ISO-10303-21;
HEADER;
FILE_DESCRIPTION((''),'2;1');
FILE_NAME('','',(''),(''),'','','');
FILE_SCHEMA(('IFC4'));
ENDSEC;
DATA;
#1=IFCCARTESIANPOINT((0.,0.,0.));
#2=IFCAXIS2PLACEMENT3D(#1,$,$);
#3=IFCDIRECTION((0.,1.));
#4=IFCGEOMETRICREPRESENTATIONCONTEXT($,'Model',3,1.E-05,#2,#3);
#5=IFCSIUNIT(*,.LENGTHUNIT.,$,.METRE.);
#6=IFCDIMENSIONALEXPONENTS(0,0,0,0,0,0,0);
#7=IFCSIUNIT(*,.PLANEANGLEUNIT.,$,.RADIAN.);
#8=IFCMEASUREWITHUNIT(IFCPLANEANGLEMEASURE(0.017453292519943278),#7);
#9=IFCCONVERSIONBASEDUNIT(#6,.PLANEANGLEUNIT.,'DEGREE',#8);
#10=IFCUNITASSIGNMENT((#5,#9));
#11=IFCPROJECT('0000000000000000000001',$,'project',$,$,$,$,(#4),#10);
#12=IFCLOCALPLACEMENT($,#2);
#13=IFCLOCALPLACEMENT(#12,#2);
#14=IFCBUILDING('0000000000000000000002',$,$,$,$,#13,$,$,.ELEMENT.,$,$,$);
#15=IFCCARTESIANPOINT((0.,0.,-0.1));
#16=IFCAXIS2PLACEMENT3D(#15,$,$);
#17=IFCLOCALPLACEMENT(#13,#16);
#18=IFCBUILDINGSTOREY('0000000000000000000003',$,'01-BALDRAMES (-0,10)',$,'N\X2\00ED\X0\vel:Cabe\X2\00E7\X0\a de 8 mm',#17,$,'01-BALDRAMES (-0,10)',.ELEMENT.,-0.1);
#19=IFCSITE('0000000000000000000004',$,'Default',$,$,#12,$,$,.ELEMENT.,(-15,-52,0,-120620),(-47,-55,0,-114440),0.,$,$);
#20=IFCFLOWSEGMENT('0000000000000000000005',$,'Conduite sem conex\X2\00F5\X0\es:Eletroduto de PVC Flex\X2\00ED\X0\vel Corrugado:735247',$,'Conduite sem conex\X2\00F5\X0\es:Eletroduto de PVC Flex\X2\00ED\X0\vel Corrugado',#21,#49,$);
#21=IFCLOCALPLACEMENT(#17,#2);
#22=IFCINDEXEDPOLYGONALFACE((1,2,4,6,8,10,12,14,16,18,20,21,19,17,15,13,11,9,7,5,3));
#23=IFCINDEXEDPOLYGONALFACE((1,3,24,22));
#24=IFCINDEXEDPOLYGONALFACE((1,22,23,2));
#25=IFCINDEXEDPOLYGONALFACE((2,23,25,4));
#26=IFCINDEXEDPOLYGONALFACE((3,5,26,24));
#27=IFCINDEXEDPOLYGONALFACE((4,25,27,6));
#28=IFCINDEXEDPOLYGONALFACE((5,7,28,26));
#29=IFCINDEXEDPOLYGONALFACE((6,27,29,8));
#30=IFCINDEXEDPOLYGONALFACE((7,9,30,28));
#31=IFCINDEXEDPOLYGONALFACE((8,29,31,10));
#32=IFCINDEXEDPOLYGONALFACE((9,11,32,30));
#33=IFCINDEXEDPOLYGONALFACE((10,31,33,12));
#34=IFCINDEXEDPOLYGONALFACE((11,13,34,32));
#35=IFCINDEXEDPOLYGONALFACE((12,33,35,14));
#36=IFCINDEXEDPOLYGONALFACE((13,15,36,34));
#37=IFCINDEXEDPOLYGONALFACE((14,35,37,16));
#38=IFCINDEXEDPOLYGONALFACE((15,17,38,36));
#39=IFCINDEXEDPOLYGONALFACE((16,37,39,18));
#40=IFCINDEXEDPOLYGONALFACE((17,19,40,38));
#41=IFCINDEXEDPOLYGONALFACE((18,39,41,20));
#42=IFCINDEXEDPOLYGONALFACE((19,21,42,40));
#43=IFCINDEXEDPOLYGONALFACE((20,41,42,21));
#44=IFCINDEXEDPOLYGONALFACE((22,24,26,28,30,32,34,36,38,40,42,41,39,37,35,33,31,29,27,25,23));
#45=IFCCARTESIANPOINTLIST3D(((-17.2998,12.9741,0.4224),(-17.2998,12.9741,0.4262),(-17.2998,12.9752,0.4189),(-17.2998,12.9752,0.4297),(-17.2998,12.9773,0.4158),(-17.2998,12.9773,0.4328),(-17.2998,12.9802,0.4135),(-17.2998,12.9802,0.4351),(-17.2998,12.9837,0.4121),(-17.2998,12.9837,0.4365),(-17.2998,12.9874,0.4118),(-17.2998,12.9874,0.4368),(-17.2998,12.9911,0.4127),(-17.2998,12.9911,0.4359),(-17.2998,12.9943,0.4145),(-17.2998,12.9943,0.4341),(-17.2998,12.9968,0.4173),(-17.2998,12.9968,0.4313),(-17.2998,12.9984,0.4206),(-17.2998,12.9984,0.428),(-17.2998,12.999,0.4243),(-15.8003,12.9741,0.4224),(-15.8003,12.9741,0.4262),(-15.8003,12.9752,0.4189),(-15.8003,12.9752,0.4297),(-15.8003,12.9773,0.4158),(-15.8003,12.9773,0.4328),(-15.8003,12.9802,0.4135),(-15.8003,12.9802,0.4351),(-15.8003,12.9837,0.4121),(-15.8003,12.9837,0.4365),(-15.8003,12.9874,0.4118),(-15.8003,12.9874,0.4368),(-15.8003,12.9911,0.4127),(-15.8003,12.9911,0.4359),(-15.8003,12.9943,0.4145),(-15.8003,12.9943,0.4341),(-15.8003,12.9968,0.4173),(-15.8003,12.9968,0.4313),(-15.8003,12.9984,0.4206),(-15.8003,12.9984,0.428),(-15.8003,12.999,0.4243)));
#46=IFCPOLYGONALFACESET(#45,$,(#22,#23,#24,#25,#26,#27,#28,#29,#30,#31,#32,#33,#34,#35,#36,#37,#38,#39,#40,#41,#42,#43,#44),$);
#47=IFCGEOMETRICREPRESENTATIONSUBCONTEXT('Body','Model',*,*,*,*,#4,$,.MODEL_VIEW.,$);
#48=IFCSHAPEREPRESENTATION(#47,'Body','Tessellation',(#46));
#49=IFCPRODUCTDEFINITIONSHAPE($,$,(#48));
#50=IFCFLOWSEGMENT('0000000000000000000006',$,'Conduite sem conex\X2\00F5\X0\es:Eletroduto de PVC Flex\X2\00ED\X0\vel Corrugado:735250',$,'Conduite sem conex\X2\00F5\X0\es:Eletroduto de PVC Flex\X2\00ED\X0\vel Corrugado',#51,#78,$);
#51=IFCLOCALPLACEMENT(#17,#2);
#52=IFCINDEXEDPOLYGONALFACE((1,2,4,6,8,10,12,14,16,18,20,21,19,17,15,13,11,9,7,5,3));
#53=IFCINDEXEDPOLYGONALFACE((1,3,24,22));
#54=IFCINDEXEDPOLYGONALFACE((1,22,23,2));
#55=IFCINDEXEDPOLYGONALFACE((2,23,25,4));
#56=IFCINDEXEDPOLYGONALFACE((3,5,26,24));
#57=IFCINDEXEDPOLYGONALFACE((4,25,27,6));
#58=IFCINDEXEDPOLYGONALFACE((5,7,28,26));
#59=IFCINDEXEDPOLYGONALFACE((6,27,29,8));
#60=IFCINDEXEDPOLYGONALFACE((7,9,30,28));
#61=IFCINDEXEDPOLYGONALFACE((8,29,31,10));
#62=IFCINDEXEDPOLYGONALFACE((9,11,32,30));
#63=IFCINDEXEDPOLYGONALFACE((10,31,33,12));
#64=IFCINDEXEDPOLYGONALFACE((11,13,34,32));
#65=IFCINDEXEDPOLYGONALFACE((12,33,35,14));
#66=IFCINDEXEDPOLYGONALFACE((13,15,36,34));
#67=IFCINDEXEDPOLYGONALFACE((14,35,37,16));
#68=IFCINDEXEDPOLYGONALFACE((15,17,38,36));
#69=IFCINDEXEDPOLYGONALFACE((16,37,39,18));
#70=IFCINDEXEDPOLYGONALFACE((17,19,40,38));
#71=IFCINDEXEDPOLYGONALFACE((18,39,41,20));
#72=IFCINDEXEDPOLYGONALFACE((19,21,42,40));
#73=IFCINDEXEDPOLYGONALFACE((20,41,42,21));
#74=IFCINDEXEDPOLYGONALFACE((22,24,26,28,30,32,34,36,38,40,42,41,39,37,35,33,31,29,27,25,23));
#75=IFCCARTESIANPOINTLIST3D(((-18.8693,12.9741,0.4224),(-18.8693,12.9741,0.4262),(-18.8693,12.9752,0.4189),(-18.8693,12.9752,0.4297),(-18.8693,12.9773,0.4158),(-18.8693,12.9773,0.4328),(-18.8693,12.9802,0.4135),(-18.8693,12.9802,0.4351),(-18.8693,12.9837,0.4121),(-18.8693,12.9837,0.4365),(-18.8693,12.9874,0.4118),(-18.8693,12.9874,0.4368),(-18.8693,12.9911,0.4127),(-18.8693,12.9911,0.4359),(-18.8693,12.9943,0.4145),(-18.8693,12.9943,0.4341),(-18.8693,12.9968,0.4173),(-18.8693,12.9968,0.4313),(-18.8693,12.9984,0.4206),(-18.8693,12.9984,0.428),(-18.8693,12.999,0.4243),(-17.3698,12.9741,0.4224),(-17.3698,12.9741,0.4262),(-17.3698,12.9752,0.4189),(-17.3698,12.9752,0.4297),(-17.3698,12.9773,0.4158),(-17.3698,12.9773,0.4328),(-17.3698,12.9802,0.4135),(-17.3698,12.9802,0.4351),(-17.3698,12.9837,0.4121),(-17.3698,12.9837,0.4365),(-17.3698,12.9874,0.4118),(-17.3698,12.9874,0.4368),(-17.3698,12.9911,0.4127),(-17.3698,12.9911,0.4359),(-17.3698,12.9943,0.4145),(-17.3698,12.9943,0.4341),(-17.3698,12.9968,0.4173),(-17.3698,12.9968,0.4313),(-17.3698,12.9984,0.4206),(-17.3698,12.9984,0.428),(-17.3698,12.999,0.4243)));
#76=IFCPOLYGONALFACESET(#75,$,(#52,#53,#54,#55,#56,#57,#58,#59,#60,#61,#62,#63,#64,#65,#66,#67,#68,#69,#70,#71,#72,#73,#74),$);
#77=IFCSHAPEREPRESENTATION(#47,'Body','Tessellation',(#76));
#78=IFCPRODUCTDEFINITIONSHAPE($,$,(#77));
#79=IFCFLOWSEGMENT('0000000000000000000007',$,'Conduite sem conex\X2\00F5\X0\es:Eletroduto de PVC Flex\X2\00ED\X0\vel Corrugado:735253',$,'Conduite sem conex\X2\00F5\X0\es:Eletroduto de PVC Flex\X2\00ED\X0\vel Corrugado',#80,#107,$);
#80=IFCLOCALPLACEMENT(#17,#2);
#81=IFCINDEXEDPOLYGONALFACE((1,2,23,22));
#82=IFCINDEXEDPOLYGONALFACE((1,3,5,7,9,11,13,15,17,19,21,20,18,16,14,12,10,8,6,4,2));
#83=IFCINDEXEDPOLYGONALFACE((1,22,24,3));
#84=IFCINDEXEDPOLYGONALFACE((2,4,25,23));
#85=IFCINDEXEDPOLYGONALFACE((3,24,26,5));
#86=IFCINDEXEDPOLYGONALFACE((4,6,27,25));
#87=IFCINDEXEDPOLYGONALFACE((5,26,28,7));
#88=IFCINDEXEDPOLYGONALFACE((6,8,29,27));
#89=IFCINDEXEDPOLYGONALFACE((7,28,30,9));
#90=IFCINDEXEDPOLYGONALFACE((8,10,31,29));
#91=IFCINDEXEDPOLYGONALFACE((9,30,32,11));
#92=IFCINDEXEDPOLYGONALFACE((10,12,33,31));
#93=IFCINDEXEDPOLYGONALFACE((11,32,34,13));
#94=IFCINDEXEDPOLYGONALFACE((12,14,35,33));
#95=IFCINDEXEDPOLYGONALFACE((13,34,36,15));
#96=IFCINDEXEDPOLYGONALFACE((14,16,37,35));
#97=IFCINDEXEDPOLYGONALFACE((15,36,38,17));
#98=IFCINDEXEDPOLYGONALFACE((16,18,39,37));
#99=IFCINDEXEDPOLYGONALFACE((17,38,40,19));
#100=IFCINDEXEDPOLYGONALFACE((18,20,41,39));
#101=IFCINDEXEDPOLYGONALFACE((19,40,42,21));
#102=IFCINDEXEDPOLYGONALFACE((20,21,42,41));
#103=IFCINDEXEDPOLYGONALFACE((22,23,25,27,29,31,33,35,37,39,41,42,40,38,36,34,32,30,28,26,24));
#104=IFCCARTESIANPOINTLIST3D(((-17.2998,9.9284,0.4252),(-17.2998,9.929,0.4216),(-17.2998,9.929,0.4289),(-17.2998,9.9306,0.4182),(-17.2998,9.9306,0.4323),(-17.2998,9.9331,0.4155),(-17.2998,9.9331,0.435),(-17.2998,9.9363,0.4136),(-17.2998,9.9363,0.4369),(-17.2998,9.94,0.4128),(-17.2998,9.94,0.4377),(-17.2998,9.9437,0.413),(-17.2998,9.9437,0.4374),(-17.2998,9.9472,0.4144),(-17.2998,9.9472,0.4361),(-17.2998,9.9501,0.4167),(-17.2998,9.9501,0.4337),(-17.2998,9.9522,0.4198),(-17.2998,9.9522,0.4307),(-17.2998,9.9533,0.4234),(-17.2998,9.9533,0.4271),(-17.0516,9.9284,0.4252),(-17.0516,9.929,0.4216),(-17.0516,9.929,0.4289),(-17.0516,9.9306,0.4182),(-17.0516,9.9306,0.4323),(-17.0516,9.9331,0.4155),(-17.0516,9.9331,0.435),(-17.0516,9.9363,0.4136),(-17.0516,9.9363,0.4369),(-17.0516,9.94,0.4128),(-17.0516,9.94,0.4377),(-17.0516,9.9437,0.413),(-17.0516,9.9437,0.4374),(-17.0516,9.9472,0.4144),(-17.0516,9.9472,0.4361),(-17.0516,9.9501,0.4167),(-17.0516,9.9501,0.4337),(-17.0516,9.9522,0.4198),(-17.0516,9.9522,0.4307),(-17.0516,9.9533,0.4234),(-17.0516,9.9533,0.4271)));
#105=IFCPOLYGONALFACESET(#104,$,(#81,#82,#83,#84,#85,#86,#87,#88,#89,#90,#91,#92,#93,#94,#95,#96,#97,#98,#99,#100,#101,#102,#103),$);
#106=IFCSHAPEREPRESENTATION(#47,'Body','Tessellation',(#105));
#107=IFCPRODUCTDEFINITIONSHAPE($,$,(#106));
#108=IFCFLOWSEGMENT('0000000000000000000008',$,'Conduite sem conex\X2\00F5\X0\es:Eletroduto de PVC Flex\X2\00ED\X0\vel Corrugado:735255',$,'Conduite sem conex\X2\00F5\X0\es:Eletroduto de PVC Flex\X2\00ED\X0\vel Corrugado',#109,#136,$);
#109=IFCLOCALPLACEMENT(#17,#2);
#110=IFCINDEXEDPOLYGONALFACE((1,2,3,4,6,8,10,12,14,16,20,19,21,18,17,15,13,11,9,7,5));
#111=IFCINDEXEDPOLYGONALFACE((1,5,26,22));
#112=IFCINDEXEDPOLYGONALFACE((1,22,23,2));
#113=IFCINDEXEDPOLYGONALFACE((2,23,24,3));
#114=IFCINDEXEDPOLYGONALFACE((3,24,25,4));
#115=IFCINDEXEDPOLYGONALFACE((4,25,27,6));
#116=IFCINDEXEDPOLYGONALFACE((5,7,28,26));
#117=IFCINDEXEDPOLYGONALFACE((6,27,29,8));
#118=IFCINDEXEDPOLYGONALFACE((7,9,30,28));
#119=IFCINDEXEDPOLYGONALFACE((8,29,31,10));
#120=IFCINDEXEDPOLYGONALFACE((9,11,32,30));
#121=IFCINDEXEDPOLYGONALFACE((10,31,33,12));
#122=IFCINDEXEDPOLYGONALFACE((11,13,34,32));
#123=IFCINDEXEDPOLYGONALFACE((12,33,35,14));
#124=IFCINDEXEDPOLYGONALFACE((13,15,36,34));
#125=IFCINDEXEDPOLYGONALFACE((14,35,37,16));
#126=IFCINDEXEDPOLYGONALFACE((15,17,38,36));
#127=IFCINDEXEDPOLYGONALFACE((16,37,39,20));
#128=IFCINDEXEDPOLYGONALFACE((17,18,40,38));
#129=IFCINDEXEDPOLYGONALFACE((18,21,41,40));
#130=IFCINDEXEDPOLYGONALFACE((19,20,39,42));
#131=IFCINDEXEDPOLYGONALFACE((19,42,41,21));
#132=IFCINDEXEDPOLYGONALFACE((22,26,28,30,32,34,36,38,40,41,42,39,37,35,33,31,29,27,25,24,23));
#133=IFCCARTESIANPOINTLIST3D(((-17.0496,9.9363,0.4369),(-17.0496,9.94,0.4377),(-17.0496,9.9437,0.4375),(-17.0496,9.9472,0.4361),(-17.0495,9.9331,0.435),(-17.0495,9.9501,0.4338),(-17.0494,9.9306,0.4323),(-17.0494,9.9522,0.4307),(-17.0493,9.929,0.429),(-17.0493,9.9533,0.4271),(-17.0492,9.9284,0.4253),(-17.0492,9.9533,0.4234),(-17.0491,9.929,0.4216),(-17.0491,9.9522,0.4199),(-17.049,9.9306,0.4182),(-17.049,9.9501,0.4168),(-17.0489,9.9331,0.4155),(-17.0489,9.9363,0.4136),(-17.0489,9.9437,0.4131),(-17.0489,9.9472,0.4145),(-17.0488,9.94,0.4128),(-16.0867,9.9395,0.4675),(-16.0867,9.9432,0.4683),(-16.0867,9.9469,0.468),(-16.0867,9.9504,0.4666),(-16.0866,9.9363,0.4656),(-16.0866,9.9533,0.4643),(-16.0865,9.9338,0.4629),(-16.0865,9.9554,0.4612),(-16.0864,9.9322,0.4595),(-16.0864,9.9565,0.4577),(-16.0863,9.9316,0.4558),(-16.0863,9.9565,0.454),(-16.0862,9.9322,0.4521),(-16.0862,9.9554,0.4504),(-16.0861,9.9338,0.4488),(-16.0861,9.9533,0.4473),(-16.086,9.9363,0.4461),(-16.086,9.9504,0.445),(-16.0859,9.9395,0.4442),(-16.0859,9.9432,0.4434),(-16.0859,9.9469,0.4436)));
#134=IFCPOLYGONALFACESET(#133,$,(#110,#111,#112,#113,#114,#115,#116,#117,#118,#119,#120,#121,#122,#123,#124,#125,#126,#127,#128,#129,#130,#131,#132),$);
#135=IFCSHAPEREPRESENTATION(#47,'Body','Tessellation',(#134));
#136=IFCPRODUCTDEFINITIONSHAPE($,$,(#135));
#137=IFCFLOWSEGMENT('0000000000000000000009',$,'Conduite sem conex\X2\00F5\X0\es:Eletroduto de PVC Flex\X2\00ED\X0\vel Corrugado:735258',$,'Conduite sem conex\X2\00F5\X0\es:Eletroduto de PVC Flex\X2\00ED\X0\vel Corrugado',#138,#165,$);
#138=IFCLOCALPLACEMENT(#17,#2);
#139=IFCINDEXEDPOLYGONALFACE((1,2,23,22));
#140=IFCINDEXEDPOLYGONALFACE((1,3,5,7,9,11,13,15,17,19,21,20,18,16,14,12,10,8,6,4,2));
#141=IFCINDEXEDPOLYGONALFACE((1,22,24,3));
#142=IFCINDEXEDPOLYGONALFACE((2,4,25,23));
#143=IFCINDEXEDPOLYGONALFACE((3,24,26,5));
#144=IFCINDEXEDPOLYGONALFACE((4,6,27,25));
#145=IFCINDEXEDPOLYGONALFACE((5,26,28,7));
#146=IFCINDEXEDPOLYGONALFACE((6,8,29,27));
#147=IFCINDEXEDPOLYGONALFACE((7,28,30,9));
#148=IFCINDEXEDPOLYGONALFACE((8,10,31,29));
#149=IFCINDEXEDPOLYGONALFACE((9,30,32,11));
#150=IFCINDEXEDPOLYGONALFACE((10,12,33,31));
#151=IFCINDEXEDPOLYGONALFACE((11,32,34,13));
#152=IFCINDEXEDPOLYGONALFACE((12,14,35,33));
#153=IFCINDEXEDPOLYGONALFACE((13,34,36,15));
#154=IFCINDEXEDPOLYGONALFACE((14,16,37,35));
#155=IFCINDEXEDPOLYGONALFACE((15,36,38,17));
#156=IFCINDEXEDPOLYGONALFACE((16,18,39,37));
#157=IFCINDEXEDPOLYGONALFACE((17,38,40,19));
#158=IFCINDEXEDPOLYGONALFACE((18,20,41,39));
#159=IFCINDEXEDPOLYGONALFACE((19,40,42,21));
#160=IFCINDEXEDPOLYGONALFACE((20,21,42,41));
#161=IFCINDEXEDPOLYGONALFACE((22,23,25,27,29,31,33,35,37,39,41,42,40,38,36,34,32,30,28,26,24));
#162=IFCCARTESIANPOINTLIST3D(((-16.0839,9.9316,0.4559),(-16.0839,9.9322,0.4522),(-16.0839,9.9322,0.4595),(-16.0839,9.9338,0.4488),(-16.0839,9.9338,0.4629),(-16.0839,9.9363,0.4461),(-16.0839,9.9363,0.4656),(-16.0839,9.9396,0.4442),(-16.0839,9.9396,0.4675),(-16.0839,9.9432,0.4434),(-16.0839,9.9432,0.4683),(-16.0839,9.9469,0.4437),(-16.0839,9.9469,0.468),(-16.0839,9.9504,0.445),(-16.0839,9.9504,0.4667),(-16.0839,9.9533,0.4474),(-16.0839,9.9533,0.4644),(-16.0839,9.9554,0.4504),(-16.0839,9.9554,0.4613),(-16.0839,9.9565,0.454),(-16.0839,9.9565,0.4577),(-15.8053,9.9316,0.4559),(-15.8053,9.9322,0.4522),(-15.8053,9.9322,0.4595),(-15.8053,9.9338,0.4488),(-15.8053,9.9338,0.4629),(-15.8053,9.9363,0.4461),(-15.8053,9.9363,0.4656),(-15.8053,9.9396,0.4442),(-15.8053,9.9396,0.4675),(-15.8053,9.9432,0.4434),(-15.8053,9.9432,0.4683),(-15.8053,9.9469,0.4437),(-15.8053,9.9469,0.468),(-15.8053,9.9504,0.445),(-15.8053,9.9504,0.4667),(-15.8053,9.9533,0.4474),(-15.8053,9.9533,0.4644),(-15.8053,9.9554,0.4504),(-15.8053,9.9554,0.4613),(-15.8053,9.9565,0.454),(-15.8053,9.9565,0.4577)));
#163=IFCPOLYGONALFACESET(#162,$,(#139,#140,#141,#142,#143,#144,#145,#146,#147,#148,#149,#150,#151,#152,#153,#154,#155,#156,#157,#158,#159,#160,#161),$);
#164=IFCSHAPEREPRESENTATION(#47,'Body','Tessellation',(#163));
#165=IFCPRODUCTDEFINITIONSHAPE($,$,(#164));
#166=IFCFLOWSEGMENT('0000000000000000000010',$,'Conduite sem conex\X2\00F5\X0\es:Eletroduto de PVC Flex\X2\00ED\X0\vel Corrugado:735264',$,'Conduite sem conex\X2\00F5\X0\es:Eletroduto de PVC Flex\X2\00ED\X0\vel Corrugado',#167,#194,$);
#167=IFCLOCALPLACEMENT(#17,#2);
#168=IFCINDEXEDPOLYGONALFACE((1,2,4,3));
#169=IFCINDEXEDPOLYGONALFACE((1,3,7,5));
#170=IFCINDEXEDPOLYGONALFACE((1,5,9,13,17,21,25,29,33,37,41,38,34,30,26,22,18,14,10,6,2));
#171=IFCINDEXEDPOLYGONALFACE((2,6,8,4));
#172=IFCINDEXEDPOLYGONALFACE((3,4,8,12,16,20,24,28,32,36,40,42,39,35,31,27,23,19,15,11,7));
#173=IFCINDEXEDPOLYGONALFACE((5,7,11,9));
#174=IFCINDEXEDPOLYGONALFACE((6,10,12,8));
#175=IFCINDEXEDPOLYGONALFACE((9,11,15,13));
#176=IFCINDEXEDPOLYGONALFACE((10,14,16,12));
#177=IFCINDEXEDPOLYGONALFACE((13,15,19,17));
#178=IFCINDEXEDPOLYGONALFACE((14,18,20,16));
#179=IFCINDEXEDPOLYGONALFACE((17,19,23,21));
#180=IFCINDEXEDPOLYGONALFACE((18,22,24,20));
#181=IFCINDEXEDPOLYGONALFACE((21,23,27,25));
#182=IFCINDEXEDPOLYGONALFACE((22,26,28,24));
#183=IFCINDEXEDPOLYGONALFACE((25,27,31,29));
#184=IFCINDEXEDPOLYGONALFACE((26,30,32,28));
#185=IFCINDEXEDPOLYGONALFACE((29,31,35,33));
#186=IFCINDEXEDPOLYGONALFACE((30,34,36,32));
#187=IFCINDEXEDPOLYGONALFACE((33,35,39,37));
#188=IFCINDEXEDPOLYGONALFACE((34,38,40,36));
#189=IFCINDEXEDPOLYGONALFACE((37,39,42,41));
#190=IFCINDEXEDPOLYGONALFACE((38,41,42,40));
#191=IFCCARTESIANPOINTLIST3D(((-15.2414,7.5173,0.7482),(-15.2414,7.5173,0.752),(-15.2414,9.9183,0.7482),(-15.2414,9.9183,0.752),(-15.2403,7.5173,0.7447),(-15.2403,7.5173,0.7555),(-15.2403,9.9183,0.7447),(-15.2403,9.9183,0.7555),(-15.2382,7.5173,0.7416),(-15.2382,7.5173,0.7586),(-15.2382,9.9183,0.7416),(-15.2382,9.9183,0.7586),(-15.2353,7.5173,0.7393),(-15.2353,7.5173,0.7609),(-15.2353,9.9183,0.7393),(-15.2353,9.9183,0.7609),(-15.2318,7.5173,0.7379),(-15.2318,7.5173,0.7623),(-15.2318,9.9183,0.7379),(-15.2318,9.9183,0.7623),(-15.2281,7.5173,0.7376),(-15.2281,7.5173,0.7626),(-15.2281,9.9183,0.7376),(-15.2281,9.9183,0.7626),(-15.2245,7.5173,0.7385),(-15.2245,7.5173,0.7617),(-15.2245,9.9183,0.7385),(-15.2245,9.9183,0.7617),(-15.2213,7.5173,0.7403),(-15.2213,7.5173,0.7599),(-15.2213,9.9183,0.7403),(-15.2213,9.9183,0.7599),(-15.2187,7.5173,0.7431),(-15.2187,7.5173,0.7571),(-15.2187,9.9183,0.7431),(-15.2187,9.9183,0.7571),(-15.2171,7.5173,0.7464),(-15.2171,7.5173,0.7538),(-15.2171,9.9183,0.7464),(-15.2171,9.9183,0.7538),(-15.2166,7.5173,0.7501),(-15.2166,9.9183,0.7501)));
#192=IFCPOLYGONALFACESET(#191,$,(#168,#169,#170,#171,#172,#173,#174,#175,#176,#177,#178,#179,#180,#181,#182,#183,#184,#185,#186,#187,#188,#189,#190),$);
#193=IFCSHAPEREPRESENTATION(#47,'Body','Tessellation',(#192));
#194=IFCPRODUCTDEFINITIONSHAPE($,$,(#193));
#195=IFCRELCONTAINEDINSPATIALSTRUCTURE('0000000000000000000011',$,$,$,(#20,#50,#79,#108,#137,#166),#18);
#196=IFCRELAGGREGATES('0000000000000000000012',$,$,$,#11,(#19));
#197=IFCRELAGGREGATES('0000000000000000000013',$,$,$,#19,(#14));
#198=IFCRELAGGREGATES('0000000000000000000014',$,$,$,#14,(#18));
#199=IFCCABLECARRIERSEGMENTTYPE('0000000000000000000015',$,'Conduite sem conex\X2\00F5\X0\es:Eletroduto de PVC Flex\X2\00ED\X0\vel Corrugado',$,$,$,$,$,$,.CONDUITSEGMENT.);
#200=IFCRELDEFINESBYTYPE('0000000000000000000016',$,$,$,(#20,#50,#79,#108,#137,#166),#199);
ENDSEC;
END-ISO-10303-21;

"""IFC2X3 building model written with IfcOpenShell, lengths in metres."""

from ifc_helpers import new_model, entity, si_unit, converted_unit, direction, frame, frame_2d, origin, origin_2d_with_axis, place, context, subcontext, project, spatial, circle, extrude, type_object, element, save


model = new_model("IFC2X3")

# Units and contexts
model_context = context("Model", 3, precision=1e-05, world=origin(), true_north=direction((0.0, 1.0)))
body_context = subcontext(model_context, "Body", "Model", "MODEL_VIEW")
ifc_project = project(units=[si_unit("LENGTHUNIT", "METRE"), converted_unit("PLANEANGLEUNIT", "DEGREE", entity("IfcPlaneAngleMeasure", 0.017453292519943278), si_unit("PLANEANGLEUNIT", "RADIAN"), dimensions=[0, 0, 0, 0, 0, 0, 0])], contexts=[model_context])

# Site, building, storey
site_placement = place(None, origin())
site = spatial("IfcSite", under=ifc_project, at=site_placement, Name="Default", CompositionType="ELEMENT", RefLatitude=(-15, -52, 0, -120620), RefLongitude=(-47, -55, 0, -114440), RefElevation=0.0)
building_placement = place(site_placement, origin())
building = spatial("IfcBuilding", under=site, at=building_placement, CompositionType="ELEMENT")
storey_placement = place(building_placement, frame((0.0, 0.0, -0.1)))
storey = spatial("IfcBuildingStorey", under=building, at=storey_placement, Name="01-BALDRAMES (-0,10)", ObjectType="Nível:Cabeça de 8 mm", LongName="01-BALDRAMES (-0,10)", CompositionType="ELEMENT", Elevation=-0.1)

# Flow segments
cable_carrier_segment_type = type_object("IfcCableCarrierSegmentType", Name="Conduite sem conexões:Eletroduto de PVC Flexível Corrugado", PredefinedType="CONDUITSEGMENT")
flow_segment_1_placement = place(storey_placement, origin())
element("IfcFlowSegment", 1, at=flow_segment_1_placement, inside=storey, type_object=cable_carrier_segment_type, Name="Conduite sem conexões:Eletroduto de PVC Flexível Corrugado:735247", ObjectType="Conduite sem conexões:Eletroduto de PVC Flexível Corrugado", context=body_context, shape_type="SweptSolid", body=[
    extrude(circle(Radius=0.0125, at=frame_2d((0.0, 0.0), x_axis=(1.0, 0.0))), frame((-17.2998, 12.9865, 0.4243), z_axis=(1.0, 0.0, 0.0), x_axis=(0.0, 1.0, 0.0)), (0.0, 0.0, 1.0), 1.4995),
])
flow_segment_2_placement = place(storey_placement, origin())
element("IfcFlowSegment", 2, at=flow_segment_2_placement, inside=storey, type_object=cable_carrier_segment_type, Name="Conduite sem conexões:Eletroduto de PVC Flexível Corrugado:735250", ObjectType="Conduite sem conexões:Eletroduto de PVC Flexível Corrugado", context=body_context, shape_type="SweptSolid", body=[
    extrude(circle(Radius=0.0125, at=frame_2d((0.0, 0.0), x_axis=(1.0, 0.0))), frame((-18.8693, 12.9865, 0.4243), z_axis=(1.0, 0.0, 0.0), x_axis=(0.0, 1.0, 0.0)), (0.0, 0.0, 1.0), 1.4995),
])
flow_segment_3_placement = place(storey_placement, origin())
element("IfcFlowSegment", 3, at=flow_segment_3_placement, inside=storey, type_object=cable_carrier_segment_type, Name="Conduite sem conexões:Eletroduto de PVC Flexível Corrugado:735253", ObjectType="Conduite sem conexões:Eletroduto de PVC Flexível Corrugado", context=body_context, shape_type="SweptSolid", body=[
    extrude(circle(Radius=0.0125, at=origin_2d_with_axis()), frame((-17.2998, 9.9409, 0.4252), z_axis=(1.0, 0.0, 0.0), x_axis=(0.0, -1.0, 0.0)), (0.0, 0.0, 1.0), 0.2482),
])
flow_segment_4_placement = place(storey_placement, origin())
element("IfcFlowSegment", 4, at=flow_segment_4_placement, inside=storey, type_object=cable_carrier_segment_type, Name="Conduite sem conexões:Eletroduto de PVC Flexível Corrugado:735255", ObjectType="Conduite sem conexões:Eletroduto de PVC Flexível Corrugado", context=body_context, shape_type="SweptSolid", body=[
    extrude(circle(Radius=0.0125, at=origin_2d_with_axis()), frame((-17.0492, 9.9409, 0.4253), z_axis=(0.999492, 0.003323, 0.031708), x_axis=(0.003325, -0.999994, 0.0)), (0.0, 0.0, 1.0), 0.9634),
])
flow_segment_5_placement = place(storey_placement, origin())
element("IfcFlowSegment", 5, at=flow_segment_5_placement, inside=storey, type_object=cable_carrier_segment_type, Name="Conduite sem conexões:Eletroduto de PVC Flexível Corrugado:735258", ObjectType="Conduite sem conexões:Eletroduto de PVC Flexível Corrugado", context=body_context, shape_type="SweptSolid", body=[
    extrude(circle(Radius=0.0125, at=origin_2d_with_axis()), frame((-16.0839, 9.9441, 0.4559), z_axis=(1.0, 0.0, 0.0), x_axis=(0.0, -1.0, 0.0)), (0.0, 0.0, 1.0), 0.2786),
])
flow_segment_6_placement = place(storey_placement, origin())
element("IfcFlowSegment", 6, at=flow_segment_6_placement, inside=storey, type_object=cable_carrier_segment_type, Name="Conduite sem conexões:Eletroduto de PVC Flexível Corrugado:735264", ObjectType="Conduite sem conexões:Eletroduto de PVC Flexível Corrugado", context=body_context, shape_type="SweptSolid", body=[
    extrude(circle(Radius=0.0125, at=origin_2d_with_axis()), frame((-15.2291, 7.5173, 0.7501), z_axis=(0.0, 1.0, 0.0), x_axis=(1.0, 0.0, 0.0)), (0.0, 0.0, 1.0), 2.401),
])

save(model, "model.ifc")
